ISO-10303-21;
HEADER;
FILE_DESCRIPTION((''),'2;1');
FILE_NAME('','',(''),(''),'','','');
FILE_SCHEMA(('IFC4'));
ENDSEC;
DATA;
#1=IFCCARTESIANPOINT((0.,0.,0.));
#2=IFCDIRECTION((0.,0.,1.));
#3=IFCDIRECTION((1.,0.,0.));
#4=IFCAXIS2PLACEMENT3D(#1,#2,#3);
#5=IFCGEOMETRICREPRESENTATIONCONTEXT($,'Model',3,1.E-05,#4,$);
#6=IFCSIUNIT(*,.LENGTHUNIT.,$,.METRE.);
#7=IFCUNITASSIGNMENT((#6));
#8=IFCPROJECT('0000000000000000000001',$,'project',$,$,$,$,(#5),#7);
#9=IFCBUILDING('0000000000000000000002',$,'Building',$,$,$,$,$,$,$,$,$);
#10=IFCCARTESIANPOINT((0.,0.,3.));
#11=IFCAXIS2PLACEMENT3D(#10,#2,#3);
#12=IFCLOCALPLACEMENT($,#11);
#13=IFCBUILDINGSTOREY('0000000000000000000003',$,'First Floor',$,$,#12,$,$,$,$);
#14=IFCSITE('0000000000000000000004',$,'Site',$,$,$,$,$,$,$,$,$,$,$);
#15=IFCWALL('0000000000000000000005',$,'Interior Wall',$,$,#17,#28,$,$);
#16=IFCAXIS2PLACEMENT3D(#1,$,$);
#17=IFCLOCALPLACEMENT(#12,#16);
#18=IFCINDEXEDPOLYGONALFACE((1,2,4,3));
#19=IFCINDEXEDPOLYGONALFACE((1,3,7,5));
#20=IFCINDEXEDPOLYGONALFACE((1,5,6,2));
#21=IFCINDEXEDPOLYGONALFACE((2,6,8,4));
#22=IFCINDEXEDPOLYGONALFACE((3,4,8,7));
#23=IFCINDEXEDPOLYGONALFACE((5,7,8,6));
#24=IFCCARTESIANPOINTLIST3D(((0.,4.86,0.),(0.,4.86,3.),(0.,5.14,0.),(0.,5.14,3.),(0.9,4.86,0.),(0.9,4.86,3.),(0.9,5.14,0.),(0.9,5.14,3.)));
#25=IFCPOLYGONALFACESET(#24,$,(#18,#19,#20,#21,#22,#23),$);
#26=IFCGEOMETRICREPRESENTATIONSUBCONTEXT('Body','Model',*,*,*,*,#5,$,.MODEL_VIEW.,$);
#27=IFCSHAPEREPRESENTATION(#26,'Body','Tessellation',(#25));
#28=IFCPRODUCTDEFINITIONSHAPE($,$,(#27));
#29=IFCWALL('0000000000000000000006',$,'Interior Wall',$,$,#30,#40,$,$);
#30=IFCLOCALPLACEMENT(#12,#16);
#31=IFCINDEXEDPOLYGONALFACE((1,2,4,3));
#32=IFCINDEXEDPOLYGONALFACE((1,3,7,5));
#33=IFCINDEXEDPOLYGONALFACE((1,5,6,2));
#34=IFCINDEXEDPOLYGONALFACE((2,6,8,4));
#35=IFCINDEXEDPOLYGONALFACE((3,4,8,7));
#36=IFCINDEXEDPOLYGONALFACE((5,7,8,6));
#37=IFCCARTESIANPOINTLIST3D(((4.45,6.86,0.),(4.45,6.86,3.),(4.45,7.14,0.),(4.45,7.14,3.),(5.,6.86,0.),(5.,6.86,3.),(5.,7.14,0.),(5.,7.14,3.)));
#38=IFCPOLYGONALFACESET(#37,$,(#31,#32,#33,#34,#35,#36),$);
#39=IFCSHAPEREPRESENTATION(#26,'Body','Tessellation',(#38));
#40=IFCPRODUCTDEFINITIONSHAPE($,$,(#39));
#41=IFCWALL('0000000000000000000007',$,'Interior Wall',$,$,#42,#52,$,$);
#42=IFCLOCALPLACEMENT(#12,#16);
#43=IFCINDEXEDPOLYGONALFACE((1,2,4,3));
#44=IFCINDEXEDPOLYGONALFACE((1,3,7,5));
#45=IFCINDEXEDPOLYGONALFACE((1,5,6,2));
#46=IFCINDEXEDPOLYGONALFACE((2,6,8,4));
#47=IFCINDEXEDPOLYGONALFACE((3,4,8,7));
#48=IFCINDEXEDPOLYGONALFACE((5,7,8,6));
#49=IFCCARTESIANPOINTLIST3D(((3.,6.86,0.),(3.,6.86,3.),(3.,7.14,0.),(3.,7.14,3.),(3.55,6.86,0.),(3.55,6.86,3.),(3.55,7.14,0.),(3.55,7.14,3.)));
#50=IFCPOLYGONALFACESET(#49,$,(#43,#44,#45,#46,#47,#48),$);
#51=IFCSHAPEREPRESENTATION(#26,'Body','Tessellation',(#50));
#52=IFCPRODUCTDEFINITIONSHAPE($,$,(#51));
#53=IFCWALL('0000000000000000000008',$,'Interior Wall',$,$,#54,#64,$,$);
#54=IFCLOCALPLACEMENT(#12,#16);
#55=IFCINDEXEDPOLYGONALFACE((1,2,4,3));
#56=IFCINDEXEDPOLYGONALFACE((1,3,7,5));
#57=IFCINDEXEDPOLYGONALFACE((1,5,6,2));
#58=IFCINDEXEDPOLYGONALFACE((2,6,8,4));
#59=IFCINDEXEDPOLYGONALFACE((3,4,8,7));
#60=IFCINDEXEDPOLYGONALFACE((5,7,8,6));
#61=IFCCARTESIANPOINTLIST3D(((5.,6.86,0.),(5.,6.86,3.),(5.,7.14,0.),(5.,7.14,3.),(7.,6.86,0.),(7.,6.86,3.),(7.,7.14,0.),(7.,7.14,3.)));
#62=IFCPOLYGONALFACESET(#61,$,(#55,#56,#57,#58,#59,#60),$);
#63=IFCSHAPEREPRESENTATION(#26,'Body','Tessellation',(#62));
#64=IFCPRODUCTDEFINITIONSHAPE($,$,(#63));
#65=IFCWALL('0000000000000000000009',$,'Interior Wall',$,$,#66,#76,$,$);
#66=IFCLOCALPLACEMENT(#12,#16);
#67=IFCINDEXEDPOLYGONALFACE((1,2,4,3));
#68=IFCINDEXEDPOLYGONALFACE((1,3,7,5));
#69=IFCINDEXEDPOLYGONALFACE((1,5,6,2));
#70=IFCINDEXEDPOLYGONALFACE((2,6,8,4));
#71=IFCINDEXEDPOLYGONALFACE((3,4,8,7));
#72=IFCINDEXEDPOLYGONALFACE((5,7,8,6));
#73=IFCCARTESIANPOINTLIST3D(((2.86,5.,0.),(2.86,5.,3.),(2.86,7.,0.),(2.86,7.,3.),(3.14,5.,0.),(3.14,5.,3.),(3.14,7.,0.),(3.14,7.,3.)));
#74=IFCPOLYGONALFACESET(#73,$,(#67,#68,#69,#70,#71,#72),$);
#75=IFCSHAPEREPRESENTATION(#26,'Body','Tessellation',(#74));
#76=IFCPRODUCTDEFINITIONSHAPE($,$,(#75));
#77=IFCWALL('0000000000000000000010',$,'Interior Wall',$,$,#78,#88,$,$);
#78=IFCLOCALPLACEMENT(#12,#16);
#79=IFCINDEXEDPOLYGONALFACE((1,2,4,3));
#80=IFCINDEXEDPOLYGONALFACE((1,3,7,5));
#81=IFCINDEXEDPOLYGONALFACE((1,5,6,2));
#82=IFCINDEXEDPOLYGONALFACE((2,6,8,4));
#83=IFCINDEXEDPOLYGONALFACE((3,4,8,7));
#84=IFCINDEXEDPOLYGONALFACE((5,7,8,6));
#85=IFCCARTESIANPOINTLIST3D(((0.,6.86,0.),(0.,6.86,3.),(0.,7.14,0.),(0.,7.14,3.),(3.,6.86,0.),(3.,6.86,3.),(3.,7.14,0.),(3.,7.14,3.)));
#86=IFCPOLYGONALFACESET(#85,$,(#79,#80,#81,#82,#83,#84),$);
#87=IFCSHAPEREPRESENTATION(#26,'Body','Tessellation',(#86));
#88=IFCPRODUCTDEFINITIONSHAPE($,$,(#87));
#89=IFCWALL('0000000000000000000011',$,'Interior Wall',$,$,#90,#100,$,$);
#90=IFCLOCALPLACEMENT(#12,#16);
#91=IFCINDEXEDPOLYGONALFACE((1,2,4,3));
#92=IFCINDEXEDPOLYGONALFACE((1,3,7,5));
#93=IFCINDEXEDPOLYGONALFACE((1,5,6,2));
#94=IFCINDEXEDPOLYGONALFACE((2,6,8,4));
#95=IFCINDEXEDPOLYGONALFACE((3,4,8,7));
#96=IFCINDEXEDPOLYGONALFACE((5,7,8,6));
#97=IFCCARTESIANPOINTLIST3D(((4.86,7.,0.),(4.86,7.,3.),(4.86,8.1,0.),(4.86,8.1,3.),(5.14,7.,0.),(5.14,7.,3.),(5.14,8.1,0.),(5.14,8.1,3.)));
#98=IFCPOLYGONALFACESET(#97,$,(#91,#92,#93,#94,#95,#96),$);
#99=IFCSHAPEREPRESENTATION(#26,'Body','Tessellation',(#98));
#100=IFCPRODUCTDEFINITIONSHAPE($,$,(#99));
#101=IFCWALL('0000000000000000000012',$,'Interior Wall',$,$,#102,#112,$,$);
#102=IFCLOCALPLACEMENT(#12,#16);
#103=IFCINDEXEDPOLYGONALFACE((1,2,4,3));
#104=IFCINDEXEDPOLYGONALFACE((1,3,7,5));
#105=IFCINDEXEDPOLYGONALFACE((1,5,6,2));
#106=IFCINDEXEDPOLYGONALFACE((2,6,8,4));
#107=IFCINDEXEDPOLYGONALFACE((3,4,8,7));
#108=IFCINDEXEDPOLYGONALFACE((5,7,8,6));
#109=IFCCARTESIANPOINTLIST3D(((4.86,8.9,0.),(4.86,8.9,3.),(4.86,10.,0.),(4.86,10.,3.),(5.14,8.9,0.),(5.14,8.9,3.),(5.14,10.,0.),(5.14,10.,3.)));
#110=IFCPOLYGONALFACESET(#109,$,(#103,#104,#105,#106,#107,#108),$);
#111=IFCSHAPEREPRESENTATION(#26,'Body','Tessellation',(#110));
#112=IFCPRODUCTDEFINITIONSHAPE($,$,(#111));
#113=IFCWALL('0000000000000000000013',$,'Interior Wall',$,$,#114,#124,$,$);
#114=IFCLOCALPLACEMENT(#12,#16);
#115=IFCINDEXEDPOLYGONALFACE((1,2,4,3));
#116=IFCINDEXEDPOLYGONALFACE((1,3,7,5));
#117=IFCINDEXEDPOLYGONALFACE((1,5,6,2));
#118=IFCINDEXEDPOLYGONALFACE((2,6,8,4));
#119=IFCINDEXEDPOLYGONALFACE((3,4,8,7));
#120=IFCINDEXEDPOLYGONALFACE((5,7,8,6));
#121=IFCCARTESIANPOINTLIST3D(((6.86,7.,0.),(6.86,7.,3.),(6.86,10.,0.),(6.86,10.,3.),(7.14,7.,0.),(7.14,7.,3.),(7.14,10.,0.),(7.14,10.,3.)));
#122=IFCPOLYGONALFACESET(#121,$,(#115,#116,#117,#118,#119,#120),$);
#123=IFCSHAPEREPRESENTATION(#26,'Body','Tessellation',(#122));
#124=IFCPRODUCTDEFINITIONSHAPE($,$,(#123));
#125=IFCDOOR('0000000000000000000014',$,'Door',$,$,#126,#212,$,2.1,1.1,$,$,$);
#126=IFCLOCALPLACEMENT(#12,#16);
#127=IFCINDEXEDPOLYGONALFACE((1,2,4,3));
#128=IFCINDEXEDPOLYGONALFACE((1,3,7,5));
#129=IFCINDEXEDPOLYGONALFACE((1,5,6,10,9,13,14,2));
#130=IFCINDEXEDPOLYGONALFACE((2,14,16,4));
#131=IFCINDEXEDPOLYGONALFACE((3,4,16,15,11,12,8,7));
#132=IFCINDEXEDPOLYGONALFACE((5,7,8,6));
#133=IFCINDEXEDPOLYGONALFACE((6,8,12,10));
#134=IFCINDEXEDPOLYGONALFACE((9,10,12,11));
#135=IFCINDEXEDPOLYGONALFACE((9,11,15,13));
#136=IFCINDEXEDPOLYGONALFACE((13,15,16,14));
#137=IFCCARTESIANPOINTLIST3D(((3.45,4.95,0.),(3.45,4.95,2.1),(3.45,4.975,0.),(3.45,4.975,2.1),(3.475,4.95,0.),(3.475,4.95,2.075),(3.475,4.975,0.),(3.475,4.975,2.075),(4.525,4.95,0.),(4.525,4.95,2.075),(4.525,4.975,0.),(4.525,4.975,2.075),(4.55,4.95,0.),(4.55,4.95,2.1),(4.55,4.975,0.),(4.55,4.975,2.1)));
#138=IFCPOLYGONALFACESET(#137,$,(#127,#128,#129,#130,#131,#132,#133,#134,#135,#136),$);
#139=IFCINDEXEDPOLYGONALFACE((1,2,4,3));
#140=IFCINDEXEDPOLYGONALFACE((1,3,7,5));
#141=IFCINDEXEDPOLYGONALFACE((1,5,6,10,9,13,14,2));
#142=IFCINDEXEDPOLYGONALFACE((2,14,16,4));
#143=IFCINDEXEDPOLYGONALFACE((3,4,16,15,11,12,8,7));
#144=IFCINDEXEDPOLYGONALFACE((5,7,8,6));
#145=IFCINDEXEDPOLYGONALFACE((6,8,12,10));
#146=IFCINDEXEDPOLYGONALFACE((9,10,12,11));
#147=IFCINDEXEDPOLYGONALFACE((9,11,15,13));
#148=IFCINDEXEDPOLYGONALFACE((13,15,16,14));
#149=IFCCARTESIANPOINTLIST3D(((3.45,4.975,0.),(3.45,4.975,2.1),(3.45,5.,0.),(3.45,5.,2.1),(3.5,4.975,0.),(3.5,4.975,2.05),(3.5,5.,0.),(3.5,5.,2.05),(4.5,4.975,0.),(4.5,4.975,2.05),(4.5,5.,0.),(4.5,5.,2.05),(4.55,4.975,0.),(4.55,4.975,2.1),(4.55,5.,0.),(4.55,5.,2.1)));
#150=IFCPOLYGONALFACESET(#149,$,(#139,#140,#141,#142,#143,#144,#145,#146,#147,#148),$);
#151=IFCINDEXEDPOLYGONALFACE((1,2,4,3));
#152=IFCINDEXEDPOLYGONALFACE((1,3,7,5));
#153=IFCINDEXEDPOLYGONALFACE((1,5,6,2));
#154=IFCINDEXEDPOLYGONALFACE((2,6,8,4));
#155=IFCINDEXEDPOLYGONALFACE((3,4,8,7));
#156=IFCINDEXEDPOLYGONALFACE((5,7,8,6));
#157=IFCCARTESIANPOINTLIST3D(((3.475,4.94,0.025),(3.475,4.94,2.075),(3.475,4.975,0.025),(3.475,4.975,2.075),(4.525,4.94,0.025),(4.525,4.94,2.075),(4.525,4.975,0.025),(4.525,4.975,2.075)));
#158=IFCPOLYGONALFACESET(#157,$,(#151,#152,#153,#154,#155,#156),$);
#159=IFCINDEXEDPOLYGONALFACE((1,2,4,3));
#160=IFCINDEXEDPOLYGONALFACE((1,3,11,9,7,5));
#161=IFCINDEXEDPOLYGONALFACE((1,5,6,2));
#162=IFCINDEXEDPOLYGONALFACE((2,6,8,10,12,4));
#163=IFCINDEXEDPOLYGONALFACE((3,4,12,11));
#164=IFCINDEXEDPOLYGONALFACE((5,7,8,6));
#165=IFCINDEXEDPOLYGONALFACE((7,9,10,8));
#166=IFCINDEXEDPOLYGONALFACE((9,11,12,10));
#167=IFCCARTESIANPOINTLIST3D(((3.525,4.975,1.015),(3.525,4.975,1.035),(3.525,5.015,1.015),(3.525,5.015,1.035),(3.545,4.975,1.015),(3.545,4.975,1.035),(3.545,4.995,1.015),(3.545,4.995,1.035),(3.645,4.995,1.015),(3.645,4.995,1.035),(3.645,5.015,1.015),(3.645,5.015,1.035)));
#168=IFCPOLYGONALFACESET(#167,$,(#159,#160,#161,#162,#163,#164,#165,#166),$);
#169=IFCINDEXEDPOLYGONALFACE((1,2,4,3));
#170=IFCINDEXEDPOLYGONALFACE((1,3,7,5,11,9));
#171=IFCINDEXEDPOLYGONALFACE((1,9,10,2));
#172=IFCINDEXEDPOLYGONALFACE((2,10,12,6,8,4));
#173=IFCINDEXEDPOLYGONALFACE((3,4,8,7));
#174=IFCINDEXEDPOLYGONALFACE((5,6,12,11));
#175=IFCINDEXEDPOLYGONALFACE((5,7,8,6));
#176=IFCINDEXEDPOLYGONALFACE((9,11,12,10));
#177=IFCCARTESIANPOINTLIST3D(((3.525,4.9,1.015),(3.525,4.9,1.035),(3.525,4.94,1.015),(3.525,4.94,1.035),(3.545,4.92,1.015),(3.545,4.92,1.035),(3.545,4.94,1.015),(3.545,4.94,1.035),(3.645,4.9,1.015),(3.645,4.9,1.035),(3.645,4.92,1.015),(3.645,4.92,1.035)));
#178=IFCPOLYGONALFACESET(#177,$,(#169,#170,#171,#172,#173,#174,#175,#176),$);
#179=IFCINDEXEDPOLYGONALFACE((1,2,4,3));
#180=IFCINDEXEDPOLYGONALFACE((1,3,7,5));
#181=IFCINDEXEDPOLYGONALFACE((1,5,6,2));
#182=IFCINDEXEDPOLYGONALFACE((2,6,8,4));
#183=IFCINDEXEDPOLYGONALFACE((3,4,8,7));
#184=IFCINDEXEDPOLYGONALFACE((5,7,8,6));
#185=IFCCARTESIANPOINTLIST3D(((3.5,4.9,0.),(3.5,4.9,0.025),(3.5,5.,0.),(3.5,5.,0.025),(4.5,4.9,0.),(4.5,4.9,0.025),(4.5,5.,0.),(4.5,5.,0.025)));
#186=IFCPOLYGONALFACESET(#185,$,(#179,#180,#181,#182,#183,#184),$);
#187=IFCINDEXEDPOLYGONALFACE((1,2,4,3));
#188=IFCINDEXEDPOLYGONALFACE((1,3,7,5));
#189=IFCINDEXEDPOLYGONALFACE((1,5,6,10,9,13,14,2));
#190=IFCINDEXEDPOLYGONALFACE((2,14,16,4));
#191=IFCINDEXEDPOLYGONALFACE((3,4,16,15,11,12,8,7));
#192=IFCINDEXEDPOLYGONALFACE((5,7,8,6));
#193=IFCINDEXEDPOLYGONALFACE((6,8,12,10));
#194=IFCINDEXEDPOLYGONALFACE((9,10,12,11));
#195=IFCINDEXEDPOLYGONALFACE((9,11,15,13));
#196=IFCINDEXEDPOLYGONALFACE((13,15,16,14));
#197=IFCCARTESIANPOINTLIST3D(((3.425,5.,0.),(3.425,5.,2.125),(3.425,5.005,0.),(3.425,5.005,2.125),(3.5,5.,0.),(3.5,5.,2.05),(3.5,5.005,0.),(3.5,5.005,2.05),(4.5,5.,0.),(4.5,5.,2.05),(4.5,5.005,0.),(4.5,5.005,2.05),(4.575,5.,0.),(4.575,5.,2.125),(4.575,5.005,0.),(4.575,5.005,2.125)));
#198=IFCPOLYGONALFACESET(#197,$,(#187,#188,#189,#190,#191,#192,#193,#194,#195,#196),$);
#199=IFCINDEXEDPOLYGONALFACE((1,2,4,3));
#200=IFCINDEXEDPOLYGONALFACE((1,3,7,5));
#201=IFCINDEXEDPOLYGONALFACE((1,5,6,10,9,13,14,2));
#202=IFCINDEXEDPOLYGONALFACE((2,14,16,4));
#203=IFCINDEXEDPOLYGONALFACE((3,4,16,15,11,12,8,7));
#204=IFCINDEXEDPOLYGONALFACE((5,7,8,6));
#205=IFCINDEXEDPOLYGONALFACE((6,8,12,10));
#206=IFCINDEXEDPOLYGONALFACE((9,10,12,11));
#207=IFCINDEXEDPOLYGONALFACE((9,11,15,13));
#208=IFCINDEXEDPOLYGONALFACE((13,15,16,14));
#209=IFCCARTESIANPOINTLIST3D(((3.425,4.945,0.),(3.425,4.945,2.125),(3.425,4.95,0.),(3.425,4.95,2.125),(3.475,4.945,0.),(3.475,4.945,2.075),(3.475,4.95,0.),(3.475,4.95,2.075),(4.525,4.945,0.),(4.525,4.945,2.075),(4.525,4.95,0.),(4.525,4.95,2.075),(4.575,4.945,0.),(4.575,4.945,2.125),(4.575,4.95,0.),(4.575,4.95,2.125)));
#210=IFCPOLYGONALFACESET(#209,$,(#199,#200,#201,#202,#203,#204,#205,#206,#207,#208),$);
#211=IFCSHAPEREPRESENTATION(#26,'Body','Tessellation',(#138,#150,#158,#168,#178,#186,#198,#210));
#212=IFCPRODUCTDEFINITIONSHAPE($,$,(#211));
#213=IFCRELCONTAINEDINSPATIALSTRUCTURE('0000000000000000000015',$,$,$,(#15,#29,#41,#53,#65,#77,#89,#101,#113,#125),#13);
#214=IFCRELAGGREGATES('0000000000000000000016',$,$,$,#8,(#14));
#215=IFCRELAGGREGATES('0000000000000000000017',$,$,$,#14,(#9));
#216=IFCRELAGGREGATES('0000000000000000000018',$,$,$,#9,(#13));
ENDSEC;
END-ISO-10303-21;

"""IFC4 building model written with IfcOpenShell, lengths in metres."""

from ifc_helpers import new_model, si_unit, frame, origin_with_axes, place, context, subcontext, project, spatial, line, indexed_curve, outline, extrude, element, save


model = new_model("IFC4")

# Units and contexts
model_context = context("Model", 3, precision=1e-05, world=origin_with_axes())
body_context = subcontext(model_context, "Body", "Model", "MODEL_VIEW")
ifc_project = project(units=[si_unit("LENGTHUNIT", "METRE")], contexts=[model_context])

# Site, building, storey
site = spatial("IfcSite", under=ifc_project, Name="Site")
building = spatial("IfcBuilding", under=site, Name="Building")
storey_placement = place(None, frame((0.0, 0.0, 3.0), z_axis=(0.0, 0.0, 1.0), x_axis=(1.0, 0.0, 0.0)))
storey = spatial("IfcBuildingStorey", under=building, at=storey_placement, Name="First Floor")

# Walls
for number, where, z_axis, x_axis, name in (
    (1, (0.9, 5.0, 0.0), (0.0, 0.0, 1.0), (-1.0, 0.0, 0.0), "Interior Wall"),
):
    element("IfcWall", number, at=place(storey_placement, frame(where, z_axis=z_axis, x_axis=x_axis)), inside=storey, Name=name, context=body_context, shape_type="SweptSolid", body=[
        extrude(outline(indexed_curve([(0.0, 0.0), (0.0, 0.28), (0.9, 0.28), (0.9, 0.0), (0.0, 0.0)], self_intersect=False)), frame((0.0, -0.14, 0.0), z_axis=(0.0, 0.0, 1.0), x_axis=(1.0, 0.0, 0.0)), (0.0, 0.0, 1.0), 3.0),
    ])
for number, where, z_axis, x_axis, name in (
    (2, (5.0, 7.0, 0.0), (0.0, 0.0, 1.0), (-1.0, 0.0, 0.0), "Interior Wall"),
    (3, (3.55, 7.0, 0.0), (0.0, 0.0, 1.0), (-1.0, 0.0, 0.0), "Interior Wall"),
):
    element("IfcWall", number, at=place(storey_placement, frame(where, z_axis=z_axis, x_axis=x_axis)), inside=storey, Name=name, context=body_context, shape_type="SweptSolid", body=[
        extrude(outline(indexed_curve([(0.0, 0.0), (0.0, 0.28), (0.55, 0.28), (0.55, 0.0), (0.0, 0.0)], self_intersect=False)), frame((0.0, -0.14, 0.0), z_axis=(0.0, 0.0, 1.0), x_axis=(1.0, 0.0, 0.0)), (0.0, 0.0, 1.0), 3.0),
    ])
for number, where, z_axis, x_axis, name in (
    (4, (7.0, 7.0, 0.0), (0.0, 0.0, 1.0), (-1.0, 0.0, 0.0), "Interior Wall"),
    (5, (3.0, 7.0, 0.0), (0.0, 0.0, 1.0), (0.0, -1.0, 0.0), "Interior Wall"),
):
    element("IfcWall", number, at=place(storey_placement, frame(where, z_axis=z_axis, x_axis=x_axis)), inside=storey, Name=name, context=body_context, shape_type="SweptSolid", body=[
        extrude(outline(indexed_curve([(0.0, 0.0), (0.0, 0.28), (2.0, 0.28), (2.0, 0.0), (0.0, 0.0)], self_intersect=False)), frame((0.0, -0.14, 0.0), z_axis=(0.0, 0.0, 1.0), x_axis=(1.0, 0.0, 0.0)), (0.0, 0.0, 1.0), 3.0),
    ])
wall_1_placement = place(storey_placement, frame((3.0, 7.0, 0.0), z_axis=(0.0, 0.0, 1.0), x_axis=(-1.0, 0.0, 0.0)))
element("IfcWall", 6, at=wall_1_placement, inside=storey, Name="Interior Wall", context=body_context, shape_type="SweptSolid", body=[
    extrude(outline(indexed_curve([(0.0, 0.0), (0.0, 0.28), (3.0, 0.28), (3.0, 0.0), (0.0, 0.0)], self_intersect=False)), frame((0.0, -0.14, 0.0), z_axis=(0.0, 0.0, 1.0), x_axis=(1.0, 0.0, 0.0)), (0.0, 0.0, 1.0), 3.0),
])
for number, where, z_axis, x_axis, name in (
    (7, (5.0, 7.0, 0.0), (0.0, 0.0, 1.0), (0.0, 1.0, 0.0), "Interior Wall"),
    (8, (5.0, 8.9, 0.0), (0.0, 0.0, 1.0), (0.0, 1.0, 0.0), "Interior Wall"),
):
    element("IfcWall", number, at=place(storey_placement, frame(where, z_axis=z_axis, x_axis=x_axis)), inside=storey, Name=name, context=body_context, shape_type="SweptSolid", body=[
        extrude(outline(indexed_curve([(0.0, 0.0), (0.0, 0.28), (1.1, 0.28), (1.1, 0.0), (0.0, 0.0)], self_intersect=False)), frame((0.0, -0.14, 0.0), z_axis=(0.0, 0.0, 1.0), x_axis=(1.0, 0.0, 0.0)), (0.0, 0.0, 1.0), 3.0),
    ])
wall_2_placement = place(storey_placement, frame((7.0, 7.0, 0.0), z_axis=(0.0, 0.0, 1.0), x_axis=(0.0, 1.0, 0.0)))
element("IfcWall", 9, at=wall_2_placement, inside=storey, Name="Interior Wall", context=body_context, shape_type="SweptSolid", body=[
    extrude(outline(indexed_curve([(0.0, 0.0), (0.0, 0.28), (3.0, 0.28), (3.0, 0.0), (0.0, 0.0)], self_intersect=False)), frame((0.0, -0.14, 0.0), z_axis=(0.0, 0.0, 1.0), x_axis=(1.0, 0.0, 0.0)), (0.0, 0.0, 1.0), 3.0),
])

# Door
door_1_placement = place(storey_placement, frame((4.55, 5.0, 0.0), z_axis=(0.0, 0.0, 1.0), x_axis=(-1.0, 0.0, 0.0)))
element("IfcDoor", 10, at=door_1_placement, inside=storey, Name="Door", OverallHeight=2.1, OverallWidth=1.1, context=body_context, shape_type="SweptSolid", body=[
    extrude(outline(indexed_curve([(0.0, 0.0), (0.0, 2.1), (1.1, 2.1), (1.1, 0.0), (1.075, 0.0), (1.075, 2.075), (0.025, 2.075), (0.025, 0.0)], segments=[line(1, 2, 3, 4, 5, 6, 7, 8, 1)])), frame((0.0, 0.025, 0.0), z_axis=(0.0, -1.0, 0.0), x_axis=(1.0, 0.0, 0.0)), (0.0, 0.0, -1.0), 0.025),
    extrude(outline(indexed_curve([(0.0, 0.0), (0.0, 2.1), (1.1, 2.1), (1.1, 0.0), (1.05, 0.0), (1.05, 2.05), (0.05, 2.05), (0.05, 0.0)], segments=[line(1, 2, 3, 4, 5, 6, 7, 8, 1)])), frame((0.0, 0.0, 0.0), z_axis=(0.0, -1.0, 0.0), x_axis=(1.0, 0.0, 0.0)), (0.0, 0.0, -1.0), 0.025),
    extrude(outline(indexed_curve([(0.0, 0.0), (1.05, 0.0), (1.05, 0.035), (0.0, 0.035)], segments=[line(1, 2, 3, 4, 1)])), frame((0.025, 0.025, 0.025), z_axis=(0.0, 0.0, 1.0), x_axis=(1.0, 0.0, 0.0)), (0.0, 0.0, 1.0), 2.05),
    extrude(outline(indexed_curve([(0.0, 0.0), (0.0, -0.04), (-0.12, -0.04), (-0.12, -0.02), (-0.02, -0.02), (-0.02, 0.0)], segments=[line(1, 2, 3, 4, 5, 6, 1)])), frame((1.025, 0.025, 1.015), z_axis=(0.0, 0.0, 1.0), x_axis=(1.0, 0.0, 0.0)), (0.0, 0.0, 1.0), 0.02),
    extrude(outline(indexed_curve([(0.0, 0.0), (0.0, 0.04), (-0.12, 0.04), (-0.12, 0.02), (-0.02, 0.02), (-0.02, 0.0)], segments=[line(1, 2, 3, 4, 5, 6, 1)])), frame((1.025, 0.06, 1.015), z_axis=(0.0, 0.0, 1.0), x_axis=(1.0, 0.0, 0.0)), (0.0, 0.0, 1.0), 0.02),
    extrude(outline(indexed_curve([(0.0, 0.0), (1.0, 0.0), (1.0, 0.1), (0.0, 0.1)], segments=[line(1, 2, 3, 4, 1)])), frame((0.05, 0.0, 0.0), z_axis=(0.0, 0.0, 1.0), x_axis=(1.0, 0.0, 0.0)), (0.0, 0.0, 1.0), 0.025),
    extrude(outline(indexed_curve([(0.0, 0.0), (0.0, 2.125), (1.15, 2.125), (1.15, 0.0), (1.075, 0.0), (1.075, 2.05), (0.075, 2.05), (0.075, 0.0)], segments=[line(1, 2, 3, 4, 5, 6, 7, 8, 1)])), frame((-0.025, -0.005, 0.0), z_axis=(0.0, -1.0, 0.0), x_axis=(1.0, 0.0, 0.0)), (0.0, 0.0, -1.0), 0.005),
    extrude(outline(indexed_curve([(0.0, 0.0), (0.0, 2.125), (1.15, 2.125), (1.15, 0.0), (1.1, 0.0), (1.1, 2.075), (0.05, 2.075), (0.05, 0.0)], segments=[line(1, 2, 3, 4, 5, 6, 7, 8, 1)])), frame((-0.025, 0.05, 0.0), z_axis=(0.0, -1.0, 0.0), x_axis=(1.0, 0.0, 0.0)), (0.0, 0.0, -1.0), 0.005),
])

save(model, "model.ifc")
